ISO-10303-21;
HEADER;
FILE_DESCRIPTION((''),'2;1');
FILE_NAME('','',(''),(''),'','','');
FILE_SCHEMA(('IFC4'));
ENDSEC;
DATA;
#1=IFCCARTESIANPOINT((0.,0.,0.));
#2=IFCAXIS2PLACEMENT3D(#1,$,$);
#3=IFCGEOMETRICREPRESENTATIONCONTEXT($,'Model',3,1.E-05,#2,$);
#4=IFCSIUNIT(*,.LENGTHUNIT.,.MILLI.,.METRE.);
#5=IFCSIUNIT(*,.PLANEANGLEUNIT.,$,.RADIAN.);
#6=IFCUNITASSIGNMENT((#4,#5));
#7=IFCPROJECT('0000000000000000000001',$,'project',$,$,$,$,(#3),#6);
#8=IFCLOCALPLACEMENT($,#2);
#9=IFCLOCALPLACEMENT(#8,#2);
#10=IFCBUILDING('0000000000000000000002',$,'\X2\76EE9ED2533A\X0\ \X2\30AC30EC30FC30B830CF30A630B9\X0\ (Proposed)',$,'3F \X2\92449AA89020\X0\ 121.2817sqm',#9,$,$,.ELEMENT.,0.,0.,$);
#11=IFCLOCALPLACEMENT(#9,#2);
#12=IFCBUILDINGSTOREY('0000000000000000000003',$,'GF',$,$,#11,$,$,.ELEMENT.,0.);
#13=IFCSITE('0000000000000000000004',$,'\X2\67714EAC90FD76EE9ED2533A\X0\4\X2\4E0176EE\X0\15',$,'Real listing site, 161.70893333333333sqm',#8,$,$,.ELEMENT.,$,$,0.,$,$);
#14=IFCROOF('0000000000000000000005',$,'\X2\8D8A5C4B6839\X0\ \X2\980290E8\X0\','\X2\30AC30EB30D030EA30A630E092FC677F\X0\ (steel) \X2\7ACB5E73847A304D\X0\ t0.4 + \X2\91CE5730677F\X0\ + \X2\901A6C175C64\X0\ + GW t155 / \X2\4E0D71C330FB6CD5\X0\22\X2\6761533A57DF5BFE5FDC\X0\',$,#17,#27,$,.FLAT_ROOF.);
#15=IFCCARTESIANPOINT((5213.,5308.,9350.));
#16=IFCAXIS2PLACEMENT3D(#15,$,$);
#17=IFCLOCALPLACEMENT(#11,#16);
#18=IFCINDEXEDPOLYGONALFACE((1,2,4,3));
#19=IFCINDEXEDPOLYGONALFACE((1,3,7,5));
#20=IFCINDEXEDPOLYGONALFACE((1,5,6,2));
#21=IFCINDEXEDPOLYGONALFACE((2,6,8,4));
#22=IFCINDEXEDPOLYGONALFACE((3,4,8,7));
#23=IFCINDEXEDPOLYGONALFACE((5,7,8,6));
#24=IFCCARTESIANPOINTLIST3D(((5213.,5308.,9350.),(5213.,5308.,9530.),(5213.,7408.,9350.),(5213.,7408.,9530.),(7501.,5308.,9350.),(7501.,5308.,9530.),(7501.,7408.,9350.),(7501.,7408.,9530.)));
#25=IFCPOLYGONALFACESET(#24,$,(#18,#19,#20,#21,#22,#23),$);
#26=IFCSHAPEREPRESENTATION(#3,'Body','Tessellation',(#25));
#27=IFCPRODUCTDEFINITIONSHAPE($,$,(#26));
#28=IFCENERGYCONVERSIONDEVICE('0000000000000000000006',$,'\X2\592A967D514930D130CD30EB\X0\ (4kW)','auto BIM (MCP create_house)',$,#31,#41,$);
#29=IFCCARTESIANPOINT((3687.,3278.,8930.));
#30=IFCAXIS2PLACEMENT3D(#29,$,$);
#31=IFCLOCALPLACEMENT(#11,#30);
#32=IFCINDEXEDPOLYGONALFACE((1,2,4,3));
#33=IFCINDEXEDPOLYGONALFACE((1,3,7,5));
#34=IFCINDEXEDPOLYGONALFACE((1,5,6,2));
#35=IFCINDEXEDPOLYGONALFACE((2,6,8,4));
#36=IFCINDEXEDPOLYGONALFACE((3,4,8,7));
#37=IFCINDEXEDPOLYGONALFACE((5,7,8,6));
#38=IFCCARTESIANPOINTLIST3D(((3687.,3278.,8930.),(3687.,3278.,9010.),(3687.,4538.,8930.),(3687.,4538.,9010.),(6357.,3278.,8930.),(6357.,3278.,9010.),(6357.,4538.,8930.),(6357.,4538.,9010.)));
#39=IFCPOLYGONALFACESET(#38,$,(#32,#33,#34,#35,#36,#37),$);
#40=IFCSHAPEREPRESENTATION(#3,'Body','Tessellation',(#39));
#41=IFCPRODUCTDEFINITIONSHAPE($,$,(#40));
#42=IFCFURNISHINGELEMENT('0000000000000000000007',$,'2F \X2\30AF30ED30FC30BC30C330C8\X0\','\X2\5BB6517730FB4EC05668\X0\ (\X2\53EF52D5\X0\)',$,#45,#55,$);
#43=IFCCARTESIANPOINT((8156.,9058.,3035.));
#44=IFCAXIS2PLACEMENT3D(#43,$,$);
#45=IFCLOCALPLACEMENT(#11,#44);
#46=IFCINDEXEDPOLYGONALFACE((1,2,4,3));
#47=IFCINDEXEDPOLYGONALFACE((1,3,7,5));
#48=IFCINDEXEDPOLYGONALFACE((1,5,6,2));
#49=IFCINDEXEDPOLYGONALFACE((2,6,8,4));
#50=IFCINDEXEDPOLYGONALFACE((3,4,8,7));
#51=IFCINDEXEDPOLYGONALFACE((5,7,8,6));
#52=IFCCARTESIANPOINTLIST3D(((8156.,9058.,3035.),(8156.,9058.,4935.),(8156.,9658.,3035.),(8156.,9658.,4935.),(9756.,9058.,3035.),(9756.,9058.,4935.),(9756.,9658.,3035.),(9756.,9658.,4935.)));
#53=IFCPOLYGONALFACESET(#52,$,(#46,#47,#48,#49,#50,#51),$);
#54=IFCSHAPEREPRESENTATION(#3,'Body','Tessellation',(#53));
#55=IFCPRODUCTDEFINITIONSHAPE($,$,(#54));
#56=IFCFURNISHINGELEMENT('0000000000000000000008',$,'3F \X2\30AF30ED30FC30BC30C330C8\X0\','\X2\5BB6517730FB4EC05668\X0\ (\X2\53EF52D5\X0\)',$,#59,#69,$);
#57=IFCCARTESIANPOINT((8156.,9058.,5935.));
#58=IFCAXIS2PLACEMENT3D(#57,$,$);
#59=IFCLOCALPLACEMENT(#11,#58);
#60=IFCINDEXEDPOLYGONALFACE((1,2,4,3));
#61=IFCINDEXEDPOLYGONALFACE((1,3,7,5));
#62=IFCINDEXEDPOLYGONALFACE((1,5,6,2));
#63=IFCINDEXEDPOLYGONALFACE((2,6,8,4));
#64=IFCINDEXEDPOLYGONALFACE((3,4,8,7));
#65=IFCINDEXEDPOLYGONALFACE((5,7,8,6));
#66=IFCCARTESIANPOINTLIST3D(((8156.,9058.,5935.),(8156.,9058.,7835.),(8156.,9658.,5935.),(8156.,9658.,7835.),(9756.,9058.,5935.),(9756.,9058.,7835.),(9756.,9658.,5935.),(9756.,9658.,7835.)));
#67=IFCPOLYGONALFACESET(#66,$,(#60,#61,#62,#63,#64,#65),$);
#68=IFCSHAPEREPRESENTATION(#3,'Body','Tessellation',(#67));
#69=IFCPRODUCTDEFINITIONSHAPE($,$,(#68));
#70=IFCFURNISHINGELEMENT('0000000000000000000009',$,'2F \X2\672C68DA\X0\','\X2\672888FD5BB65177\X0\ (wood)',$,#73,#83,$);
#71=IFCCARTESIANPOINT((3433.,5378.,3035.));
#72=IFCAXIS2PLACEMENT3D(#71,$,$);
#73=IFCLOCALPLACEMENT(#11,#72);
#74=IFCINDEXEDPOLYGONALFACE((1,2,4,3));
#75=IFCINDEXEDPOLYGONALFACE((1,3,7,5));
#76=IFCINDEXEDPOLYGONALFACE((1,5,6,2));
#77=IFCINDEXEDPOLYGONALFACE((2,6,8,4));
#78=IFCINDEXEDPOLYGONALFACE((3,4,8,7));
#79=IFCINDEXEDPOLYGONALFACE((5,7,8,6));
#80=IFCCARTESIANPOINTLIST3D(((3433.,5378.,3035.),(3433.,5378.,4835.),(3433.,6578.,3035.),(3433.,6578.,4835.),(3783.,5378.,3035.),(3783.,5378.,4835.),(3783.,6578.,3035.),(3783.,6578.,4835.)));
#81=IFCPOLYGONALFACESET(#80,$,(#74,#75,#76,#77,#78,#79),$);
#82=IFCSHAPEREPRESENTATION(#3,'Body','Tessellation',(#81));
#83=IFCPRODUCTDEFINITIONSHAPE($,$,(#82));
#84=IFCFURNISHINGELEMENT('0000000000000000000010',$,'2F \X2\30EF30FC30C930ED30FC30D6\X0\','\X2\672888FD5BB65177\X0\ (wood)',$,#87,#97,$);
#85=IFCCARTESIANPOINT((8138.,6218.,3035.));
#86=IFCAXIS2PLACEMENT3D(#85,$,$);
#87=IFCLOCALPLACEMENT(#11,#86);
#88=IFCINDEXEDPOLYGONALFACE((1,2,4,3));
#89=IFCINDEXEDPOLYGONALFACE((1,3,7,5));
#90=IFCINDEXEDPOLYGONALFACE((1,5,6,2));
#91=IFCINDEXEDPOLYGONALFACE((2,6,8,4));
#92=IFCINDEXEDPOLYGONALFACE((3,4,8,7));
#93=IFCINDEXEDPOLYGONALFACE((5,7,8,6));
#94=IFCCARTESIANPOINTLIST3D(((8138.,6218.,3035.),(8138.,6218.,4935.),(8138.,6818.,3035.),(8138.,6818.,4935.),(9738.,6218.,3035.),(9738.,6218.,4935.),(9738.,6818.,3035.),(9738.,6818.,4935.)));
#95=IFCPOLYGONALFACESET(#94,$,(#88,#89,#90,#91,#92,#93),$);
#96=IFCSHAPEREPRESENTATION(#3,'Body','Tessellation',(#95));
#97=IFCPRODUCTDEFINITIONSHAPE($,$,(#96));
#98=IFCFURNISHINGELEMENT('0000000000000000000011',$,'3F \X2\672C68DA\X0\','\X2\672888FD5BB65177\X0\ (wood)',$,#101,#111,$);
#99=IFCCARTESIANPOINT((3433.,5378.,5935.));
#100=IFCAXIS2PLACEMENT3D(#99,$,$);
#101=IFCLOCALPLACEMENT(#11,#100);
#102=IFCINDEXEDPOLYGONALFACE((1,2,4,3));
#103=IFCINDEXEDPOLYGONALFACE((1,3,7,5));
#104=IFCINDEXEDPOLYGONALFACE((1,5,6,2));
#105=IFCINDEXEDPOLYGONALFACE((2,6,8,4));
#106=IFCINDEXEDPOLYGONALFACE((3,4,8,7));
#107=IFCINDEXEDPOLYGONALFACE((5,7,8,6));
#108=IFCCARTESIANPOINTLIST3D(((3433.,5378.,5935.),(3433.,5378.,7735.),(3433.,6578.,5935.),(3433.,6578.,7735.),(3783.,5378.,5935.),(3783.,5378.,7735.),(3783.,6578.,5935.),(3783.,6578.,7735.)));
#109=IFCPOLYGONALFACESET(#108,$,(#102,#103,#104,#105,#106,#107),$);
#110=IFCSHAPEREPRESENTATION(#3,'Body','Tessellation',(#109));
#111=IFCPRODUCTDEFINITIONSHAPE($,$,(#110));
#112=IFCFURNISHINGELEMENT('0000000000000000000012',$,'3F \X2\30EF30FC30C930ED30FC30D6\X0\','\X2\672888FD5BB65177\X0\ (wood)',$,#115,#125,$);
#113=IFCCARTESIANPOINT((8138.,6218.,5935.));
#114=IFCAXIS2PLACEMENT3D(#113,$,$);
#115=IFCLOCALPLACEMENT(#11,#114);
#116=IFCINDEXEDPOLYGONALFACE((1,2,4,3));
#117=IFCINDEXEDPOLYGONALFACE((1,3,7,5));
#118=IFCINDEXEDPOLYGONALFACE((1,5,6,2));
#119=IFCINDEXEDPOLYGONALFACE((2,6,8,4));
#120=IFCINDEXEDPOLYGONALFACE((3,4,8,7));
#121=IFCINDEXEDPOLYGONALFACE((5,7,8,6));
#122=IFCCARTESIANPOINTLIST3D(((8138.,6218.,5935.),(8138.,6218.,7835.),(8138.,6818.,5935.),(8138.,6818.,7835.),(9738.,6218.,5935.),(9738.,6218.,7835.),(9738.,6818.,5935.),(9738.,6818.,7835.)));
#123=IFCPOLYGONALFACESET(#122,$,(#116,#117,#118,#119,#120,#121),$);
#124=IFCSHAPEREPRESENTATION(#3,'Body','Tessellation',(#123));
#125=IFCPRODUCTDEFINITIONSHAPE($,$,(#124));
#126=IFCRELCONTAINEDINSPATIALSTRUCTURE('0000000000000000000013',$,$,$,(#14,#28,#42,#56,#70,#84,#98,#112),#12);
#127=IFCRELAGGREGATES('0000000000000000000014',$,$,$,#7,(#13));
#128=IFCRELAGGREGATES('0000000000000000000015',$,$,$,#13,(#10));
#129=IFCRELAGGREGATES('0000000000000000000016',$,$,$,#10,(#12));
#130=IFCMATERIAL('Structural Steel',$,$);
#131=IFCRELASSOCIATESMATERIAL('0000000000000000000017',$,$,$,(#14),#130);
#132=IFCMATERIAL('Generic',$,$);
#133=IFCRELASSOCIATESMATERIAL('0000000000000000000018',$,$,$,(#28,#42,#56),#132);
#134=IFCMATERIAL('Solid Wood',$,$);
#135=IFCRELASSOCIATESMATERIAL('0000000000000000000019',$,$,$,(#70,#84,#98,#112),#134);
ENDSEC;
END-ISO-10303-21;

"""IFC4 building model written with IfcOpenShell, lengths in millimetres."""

from ifc_helpers import new_model, si_unit, frame, frame_2d, origin, place, context, project, spatial, rectangle, extrude, material, element, save


model = new_model("IFC4")

# Units and contexts
model_context = context("Model", 3, precision=1e-05, world=origin())
ifc_project = project(units=[si_unit("LENGTHUNIT", "METRE", prefix="MILLI"), si_unit("PLANEANGLEUNIT", "RADIAN")], contexts=[model_context])

# Site, building, storey
site_placement = place(None, origin())
site = spatial("IfcSite", under=ifc_project, at=site_placement, Name="東京都目黒区4丁目15", ObjectType="Real listing site, 161.70893333333333sqm", CompositionType="ELEMENT", RefElevation=0.0)
building_placement = place(site_placement, origin())
building = spatial("IfcBuilding", under=site, at=building_placement, Name="目黒区 ガレージハウス (Proposed)", ObjectType="3F 鉄骨造 121.2817sqm", CompositionType="ELEMENT", ElevationOfRefHeight=0.0, ElevationOfTerrain=0.0)
storey_placement = place(building_placement, origin())
storey = spatial("IfcBuildingStorey", under=building, at=storey_placement, Name="GF", CompositionType="ELEMENT", Elevation=0.0)

# Shared definitions
ifc_material_1 = material(Name="Solid Wood")

# Roof
ifc_material_2 = material(Name="Structural Steel")
roof_placement = place(storey_placement, frame((5213.0, 5308.0, 9350.0)))
element("IfcRoof", 1, at=roof_placement, inside=storey, material=ifc_material_2, Name="越屋根 頂部", Description="ガルバリウム鋼板 (steel) 立平葺き t0.4 + 野地板 + 通気層 + GW t155 / 不燃・法22条区域対応", PredefinedType="FLAT_ROOF", context=model_context, shape_type="SweptSolid", body=[
    extrude(rectangle(XDim=2288.0, YDim=2100.0, at=frame_2d((1144.0, 1050.0))), frame((5213.0, 5308.0, 9350.0)), (0.0, 0.0, 1.0), 180.0),
])

# Energy conversion device
ifc_material_3 = material(Name="Generic")
energy_conversion_device_placement = place(storey_placement, frame((3687.0, 3278.0, 8930.0)))
element("IfcEnergyConversionDevice", 2, at=energy_conversion_device_placement, inside=storey, material=ifc_material_3, Name="太陽光パネル (4kW)", Description="auto BIM (MCP create_house)", context=model_context, shape_type="SweptSolid", body=[
    extrude(rectangle(XDim=2670.0, YDim=1260.0, at=frame_2d((1335.0, 630.0))), frame((3687.0, 3278.0, 8930.0)), (0.0, 0.0, 1.0), 80.0),
])

# Furnishing elements
furnishing_1_placement = place(storey_placement, frame((8156.0, 9058.0, 3035.0)))
element("IfcFurnishingElement", 3, at=furnishing_1_placement, inside=storey, material=ifc_material_3, Name="2F クローゼット", Description="家具・什器 (可動)", context=model_context, shape_type="SweptSolid", body=[
    extrude(rectangle(XDim=1600.0, YDim=600.0, at=frame_2d((800.0, 300.0))), frame((8156.0, 9058.0, 3035.0)), (0.0, 0.0, 1.0), 1900.0),
])
furnishing_2_placement = place(storey_placement, frame((8156.0, 9058.0, 5935.0)))
element("IfcFurnishingElement", 4, at=furnishing_2_placement, inside=storey, material=ifc_material_3, Name="3F クローゼット", Description="家具・什器 (可動)", context=model_context, shape_type="SweptSolid", body=[
    extrude(rectangle(XDim=1600.0, YDim=600.0, at=frame_2d((800.0, 300.0))), frame((8156.0, 9058.0, 5935.0)), (0.0, 0.0, 1.0), 1900.0),
])
furnishing_3_placement = place(storey_placement, frame((3433.0, 5378.0, 3035.0)))
element("IfcFurnishingElement", 5, at=furnishing_3_placement, inside=storey, material=ifc_material_1, Name="2F 本棚", Description="木製家具 (wood)", context=model_context, shape_type="SweptSolid", body=[
    extrude(rectangle(XDim=350.0, YDim=1200.0, at=frame_2d((175.0, 600.0))), frame((3433.0, 5378.0, 3035.0)), (0.0, 0.0, 1.0), 1800.0),
])
furnishing_4_placement = place(storey_placement, frame((8138.0, 6218.0, 3035.0)))
element("IfcFurnishingElement", 6, at=furnishing_4_placement, inside=storey, material=ifc_material_1, Name="2F ワードローブ", Description="木製家具 (wood)", context=model_context, shape_type="SweptSolid", body=[
    extrude(rectangle(XDim=1600.0, YDim=600.0, at=frame_2d((800.0, 300.0))), frame((8138.0, 6218.0, 3035.0)), (0.0, 0.0, 1.0), 1900.0),
])
furnishing_5_placement = place(storey_placement, frame((3433.0, 5378.0, 5935.0)))
element("IfcFurnishingElement", 7, at=furnishing_5_placement, inside=storey, material=ifc_material_1, Name="3F 本棚", Description="木製家具 (wood)", context=model_context, shape_type="SweptSolid", body=[
    extrude(rectangle(XDim=350.0, YDim=1200.0, at=frame_2d((175.0, 600.0))), frame((3433.0, 5378.0, 5935.0)), (0.0, 0.0, 1.0), 1800.0),
])
furnishing_6_placement = place(storey_placement, frame((8138.0, 6218.0, 5935.0)))
element("IfcFurnishingElement", 8, at=furnishing_6_placement, inside=storey, material=ifc_material_1, Name="3F ワードローブ", Description="木製家具 (wood)", context=model_context, shape_type="SweptSolid", body=[
    extrude(rectangle(XDim=1600.0, YDim=600.0, at=frame_2d((800.0, 300.0))), frame((8138.0, 6218.0, 5935.0)), (0.0, 0.0, 1.0), 1900.0),
])

save(model, "model.ifc")
